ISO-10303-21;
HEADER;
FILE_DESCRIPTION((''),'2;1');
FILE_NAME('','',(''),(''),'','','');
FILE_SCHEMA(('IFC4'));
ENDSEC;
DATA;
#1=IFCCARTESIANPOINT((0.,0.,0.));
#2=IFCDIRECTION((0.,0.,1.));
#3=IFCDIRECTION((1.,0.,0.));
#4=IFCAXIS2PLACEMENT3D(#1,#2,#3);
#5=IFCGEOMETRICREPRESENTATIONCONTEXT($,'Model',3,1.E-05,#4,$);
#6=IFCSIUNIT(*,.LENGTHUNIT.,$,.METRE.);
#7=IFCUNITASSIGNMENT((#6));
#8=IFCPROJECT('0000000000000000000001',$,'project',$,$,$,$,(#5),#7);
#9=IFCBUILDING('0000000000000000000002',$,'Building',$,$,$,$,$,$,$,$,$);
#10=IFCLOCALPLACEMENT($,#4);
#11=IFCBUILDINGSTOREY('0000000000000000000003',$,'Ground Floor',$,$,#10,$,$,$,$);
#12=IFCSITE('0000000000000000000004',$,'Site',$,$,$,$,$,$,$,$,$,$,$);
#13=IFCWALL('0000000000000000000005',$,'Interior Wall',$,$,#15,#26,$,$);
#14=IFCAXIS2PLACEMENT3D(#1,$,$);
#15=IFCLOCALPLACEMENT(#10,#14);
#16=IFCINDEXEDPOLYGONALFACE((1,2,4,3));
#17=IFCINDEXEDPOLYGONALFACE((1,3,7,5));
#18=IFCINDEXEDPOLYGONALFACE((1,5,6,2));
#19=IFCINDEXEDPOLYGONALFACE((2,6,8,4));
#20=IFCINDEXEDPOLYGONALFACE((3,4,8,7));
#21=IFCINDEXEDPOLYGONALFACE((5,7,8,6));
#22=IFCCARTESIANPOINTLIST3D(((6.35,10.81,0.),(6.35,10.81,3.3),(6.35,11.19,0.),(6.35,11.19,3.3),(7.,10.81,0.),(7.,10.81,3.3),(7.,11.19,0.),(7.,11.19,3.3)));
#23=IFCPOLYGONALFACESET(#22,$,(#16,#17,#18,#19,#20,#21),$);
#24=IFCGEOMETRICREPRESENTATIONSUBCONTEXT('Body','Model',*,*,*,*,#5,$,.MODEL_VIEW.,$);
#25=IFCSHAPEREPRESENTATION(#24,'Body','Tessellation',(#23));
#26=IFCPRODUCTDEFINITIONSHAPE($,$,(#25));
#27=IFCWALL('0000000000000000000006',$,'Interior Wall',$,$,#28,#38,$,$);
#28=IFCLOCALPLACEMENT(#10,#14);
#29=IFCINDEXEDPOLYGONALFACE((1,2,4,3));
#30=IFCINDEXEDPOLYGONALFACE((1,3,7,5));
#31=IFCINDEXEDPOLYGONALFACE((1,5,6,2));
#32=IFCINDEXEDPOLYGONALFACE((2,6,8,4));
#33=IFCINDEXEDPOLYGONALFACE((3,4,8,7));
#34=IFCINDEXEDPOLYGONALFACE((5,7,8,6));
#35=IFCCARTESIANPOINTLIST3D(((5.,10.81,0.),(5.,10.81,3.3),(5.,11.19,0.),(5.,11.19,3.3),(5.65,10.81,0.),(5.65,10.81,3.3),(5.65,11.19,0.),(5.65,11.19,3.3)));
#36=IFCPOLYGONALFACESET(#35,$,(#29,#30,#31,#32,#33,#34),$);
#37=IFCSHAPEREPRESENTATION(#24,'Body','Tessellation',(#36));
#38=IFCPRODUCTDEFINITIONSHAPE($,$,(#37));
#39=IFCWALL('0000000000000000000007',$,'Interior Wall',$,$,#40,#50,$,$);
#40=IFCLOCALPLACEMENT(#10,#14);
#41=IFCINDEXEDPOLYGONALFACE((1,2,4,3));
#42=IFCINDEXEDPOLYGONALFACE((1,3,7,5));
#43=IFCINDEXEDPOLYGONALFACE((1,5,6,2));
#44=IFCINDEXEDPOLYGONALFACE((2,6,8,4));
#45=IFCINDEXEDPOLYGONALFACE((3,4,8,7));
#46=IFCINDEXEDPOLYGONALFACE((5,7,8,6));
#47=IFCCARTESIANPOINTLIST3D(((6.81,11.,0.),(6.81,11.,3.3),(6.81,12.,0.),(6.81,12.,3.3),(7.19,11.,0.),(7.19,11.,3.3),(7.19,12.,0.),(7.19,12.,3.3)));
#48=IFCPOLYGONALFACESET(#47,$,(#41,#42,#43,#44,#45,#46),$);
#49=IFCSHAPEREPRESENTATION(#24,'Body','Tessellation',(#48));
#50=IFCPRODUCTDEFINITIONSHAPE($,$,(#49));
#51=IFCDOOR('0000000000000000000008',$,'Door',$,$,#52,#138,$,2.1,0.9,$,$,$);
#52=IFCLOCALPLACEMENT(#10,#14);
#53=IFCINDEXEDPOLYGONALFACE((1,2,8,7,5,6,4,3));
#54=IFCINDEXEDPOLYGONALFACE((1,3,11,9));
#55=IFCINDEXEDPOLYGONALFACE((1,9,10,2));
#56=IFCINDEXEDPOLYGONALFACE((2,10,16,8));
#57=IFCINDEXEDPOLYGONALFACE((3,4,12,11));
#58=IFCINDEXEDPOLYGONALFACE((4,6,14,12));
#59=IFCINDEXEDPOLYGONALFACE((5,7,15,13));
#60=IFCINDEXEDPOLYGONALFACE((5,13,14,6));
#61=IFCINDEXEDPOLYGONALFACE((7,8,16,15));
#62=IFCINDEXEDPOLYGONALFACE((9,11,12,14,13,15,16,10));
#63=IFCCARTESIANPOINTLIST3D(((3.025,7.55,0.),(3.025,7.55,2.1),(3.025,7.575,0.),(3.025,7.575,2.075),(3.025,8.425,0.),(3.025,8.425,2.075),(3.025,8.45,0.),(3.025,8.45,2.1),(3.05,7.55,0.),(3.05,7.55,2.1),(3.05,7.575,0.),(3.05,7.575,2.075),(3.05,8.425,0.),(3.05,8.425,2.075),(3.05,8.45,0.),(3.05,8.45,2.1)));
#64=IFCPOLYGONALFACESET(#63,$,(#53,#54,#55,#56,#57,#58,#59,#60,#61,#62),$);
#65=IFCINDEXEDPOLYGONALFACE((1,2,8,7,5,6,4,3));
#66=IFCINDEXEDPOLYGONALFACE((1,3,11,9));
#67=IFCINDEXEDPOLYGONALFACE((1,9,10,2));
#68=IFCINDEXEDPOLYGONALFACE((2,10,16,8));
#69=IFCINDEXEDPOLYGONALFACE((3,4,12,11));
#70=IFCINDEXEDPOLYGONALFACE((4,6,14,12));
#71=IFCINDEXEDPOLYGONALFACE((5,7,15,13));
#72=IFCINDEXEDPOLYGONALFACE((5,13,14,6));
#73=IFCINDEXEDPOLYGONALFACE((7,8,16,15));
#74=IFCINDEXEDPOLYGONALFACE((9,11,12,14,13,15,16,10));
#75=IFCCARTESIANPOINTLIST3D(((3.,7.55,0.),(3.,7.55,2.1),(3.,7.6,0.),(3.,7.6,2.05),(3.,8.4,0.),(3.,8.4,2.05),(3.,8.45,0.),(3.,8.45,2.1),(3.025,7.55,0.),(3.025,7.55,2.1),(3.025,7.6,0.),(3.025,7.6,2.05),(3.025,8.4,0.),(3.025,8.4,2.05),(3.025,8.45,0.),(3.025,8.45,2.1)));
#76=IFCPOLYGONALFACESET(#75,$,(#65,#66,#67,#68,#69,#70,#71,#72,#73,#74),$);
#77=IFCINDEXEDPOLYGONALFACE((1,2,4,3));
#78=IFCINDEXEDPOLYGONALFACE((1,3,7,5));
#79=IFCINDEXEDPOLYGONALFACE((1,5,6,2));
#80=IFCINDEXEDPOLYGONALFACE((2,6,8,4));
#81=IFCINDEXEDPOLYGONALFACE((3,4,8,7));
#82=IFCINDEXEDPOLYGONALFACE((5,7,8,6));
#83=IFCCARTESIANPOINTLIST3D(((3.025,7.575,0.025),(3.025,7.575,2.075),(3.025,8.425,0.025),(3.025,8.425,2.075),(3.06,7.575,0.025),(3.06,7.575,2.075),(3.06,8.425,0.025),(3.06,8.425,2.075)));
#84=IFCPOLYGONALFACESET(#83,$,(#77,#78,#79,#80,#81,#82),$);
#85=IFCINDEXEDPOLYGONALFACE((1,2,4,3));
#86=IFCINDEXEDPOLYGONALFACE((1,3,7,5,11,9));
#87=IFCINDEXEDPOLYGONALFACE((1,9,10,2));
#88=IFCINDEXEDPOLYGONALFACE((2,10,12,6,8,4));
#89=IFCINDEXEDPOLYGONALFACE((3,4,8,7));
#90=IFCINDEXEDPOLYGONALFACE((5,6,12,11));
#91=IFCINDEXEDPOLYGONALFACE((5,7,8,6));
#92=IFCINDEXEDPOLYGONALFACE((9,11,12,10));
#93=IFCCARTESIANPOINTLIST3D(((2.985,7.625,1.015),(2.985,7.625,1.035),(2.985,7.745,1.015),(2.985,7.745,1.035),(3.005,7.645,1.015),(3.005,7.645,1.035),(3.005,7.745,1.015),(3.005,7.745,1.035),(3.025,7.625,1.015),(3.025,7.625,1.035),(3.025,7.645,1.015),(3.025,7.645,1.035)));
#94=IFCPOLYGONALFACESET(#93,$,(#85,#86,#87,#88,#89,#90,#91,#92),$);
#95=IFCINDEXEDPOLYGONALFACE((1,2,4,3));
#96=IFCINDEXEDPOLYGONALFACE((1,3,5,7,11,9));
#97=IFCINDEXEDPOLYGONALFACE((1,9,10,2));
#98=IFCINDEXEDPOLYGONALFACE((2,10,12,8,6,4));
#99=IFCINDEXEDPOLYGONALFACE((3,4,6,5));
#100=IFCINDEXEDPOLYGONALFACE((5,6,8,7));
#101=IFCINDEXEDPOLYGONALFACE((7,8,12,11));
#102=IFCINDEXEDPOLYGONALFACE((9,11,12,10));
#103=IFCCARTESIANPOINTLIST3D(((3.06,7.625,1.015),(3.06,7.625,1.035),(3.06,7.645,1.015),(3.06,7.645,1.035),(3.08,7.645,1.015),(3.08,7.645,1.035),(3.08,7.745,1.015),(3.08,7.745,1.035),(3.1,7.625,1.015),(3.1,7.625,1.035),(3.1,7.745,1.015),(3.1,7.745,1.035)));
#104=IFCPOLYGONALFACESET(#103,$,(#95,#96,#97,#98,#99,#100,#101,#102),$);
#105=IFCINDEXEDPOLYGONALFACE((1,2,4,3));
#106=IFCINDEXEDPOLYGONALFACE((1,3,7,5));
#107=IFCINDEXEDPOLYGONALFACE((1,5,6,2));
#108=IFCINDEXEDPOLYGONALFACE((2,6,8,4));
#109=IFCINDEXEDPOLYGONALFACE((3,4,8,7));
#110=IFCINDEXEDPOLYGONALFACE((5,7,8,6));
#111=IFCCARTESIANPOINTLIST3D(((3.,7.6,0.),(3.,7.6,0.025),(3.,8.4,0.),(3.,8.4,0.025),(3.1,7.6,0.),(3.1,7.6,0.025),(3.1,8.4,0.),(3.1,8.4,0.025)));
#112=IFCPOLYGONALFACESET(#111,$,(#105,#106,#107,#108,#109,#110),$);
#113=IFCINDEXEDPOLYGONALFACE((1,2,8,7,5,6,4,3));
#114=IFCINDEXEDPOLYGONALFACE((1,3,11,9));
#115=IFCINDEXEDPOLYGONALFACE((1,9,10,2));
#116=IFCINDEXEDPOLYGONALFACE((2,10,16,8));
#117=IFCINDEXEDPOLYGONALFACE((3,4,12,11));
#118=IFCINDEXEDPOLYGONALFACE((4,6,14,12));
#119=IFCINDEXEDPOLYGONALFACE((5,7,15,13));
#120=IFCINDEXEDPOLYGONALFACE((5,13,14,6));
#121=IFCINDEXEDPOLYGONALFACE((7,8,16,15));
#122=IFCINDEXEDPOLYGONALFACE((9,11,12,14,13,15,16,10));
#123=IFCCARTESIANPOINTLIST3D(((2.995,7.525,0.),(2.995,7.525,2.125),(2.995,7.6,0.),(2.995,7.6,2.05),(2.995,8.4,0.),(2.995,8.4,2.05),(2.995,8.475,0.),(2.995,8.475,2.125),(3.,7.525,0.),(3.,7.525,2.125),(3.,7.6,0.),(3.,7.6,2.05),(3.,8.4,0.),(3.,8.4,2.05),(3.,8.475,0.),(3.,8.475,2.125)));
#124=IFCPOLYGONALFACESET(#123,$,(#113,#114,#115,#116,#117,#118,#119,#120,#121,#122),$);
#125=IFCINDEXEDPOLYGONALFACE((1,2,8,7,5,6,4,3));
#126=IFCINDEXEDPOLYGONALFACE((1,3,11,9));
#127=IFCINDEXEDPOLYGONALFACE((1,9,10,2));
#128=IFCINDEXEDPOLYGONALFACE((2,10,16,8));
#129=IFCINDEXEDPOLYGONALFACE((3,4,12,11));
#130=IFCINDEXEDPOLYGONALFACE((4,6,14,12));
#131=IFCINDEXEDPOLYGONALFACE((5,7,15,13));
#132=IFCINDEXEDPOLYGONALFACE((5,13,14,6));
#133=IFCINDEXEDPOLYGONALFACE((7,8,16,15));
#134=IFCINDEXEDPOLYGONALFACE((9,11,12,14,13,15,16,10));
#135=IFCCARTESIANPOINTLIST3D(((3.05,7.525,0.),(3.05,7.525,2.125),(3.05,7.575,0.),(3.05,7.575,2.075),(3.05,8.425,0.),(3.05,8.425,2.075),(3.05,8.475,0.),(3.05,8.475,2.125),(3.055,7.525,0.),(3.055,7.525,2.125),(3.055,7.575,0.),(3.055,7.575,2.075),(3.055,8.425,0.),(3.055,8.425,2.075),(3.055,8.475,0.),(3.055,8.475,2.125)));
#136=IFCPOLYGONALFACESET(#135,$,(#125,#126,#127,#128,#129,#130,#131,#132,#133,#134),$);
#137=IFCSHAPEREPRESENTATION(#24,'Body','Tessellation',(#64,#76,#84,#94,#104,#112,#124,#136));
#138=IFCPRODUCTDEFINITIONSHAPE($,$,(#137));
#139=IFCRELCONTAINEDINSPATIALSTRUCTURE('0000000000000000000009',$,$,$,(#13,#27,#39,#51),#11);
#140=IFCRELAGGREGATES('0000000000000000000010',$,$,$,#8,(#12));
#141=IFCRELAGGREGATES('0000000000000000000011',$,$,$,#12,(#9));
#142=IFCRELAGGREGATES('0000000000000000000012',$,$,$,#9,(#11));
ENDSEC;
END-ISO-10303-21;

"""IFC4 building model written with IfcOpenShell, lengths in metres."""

from ifc_helpers import new_model, si_unit, frame, origin_with_axes, place, context, subcontext, project, spatial, line, indexed_curve, outline, extrude, element, save


model = new_model("IFC4")

# Units and contexts
model_context = context("Model", 3, precision=1e-05, world=origin_with_axes())
body_context = subcontext(model_context, "Body", "Model", "MODEL_VIEW")
ifc_project = project(units=[si_unit("LENGTHUNIT", "METRE")], contexts=[model_context])

# Site, building, storey
site = spatial("IfcSite", under=ifc_project, Name="Site")
building = spatial("IfcBuilding", under=site, Name="Building")
storey_placement = place(None, origin_with_axes())
storey = spatial("IfcBuildingStorey", under=building, at=storey_placement, Name="Ground Floor")

# Walls
for number, where, z_axis, x_axis, name in (
    (1, (7.0, 11.0, 0.0), (0.0, 0.0, 1.0), (-1.0, 0.0, 0.0), "Interior Wall"),
    (2, (5.65, 11.0, 0.0), (0.0, 0.0, 1.0), (-1.0, 0.0, 0.0), "Interior Wall"),
):
    element("IfcWall", number, at=place(storey_placement, frame(where, z_axis=z_axis, x_axis=x_axis)), inside=storey, Name=name, context=body_context, shape_type="SweptSolid", body=[
        extrude(outline(indexed_curve([(0.0, 0.0), (0.0, 0.38), (0.65, 0.38), (0.65, 0.0), (0.0, 0.0)], self_intersect=False)), frame((0.0, -0.19, 0.0), z_axis=(0.0, 0.0, 1.0), x_axis=(1.0, 0.0, 0.0)), (0.0, 0.0, 1.0), 3.3),
    ])
wall_1_placement = place(storey_placement, frame((7.0, 11.0, 0.0), z_axis=(0.0, 0.0, 1.0), x_axis=(0.0, 1.0, 0.0)))
element("IfcWall", 3, at=wall_1_placement, inside=storey, Name="Interior Wall", context=body_context, shape_type="SweptSolid", body=[
    extrude(outline(indexed_curve([(0.0, 0.0), (0.0, 0.38), (1.0, 0.38), (1.0, 0.0), (0.0, 0.0)], self_intersect=False)), frame((0.0, -0.19, 0.0), z_axis=(0.0, 0.0, 1.0), x_axis=(1.0, 0.0, 0.0)), (0.0, 0.0, 1.0), 3.3),
])

# Door
door_1_placement = place(storey_placement, frame((3.0, 8.45, 0.0), z_axis=(0.0, 0.0, 1.0), x_axis=(0.0, -1.0, 0.0)))
element("IfcDoor", 4, at=door_1_placement, inside=storey, Name="Door", OverallHeight=2.1, OverallWidth=0.9, context=body_context, shape_type="SweptSolid", body=[
    extrude(outline(indexed_curve([(0.0, 0.0), (0.0, 2.1), (0.9, 2.1), (0.9, 0.0), (0.875, 0.0), (0.875, 2.075), (0.025, 2.075), (0.025, 0.0)], segments=[line(1, 2, 3, 4, 5, 6, 7, 8, 1)])), frame((0.0, 0.025, 0.0), z_axis=(0.0, -1.0, 0.0), x_axis=(1.0, 0.0, 0.0)), (0.0, 0.0, -1.0), 0.025),
    extrude(outline(indexed_curve([(0.0, 0.0), (0.0, 2.1), (0.9, 2.1), (0.9, 0.0), (0.85, 0.0), (0.85, 2.05), (0.05, 2.05), (0.05, 0.0)], segments=[line(1, 2, 3, 4, 5, 6, 7, 8, 1)])), frame((0.0, 0.0, 0.0), z_axis=(0.0, -1.0, 0.0), x_axis=(1.0, 0.0, 0.0)), (0.0, 0.0, -1.0), 0.025),
    extrude(outline(indexed_curve([(0.0, 0.0), (0.85, 0.0), (0.85, 0.035), (0.0, 0.035)], segments=[line(1, 2, 3, 4, 1)])), frame((0.025, 0.025, 0.025), z_axis=(0.0, 0.0, 1.0), x_axis=(1.0, 0.0, 0.0)), (0.0, 0.0, 1.0), 2.05),
    extrude(outline(indexed_curve([(0.0, 0.0), (0.0, -0.04), (-0.12, -0.04), (-0.12, -0.02), (-0.02, -0.02), (-0.02, 0.0)], segments=[line(1, 2, 3, 4, 5, 6, 1)])), frame((0.825, 0.025, 1.015), z_axis=(0.0, 0.0, 1.0), x_axis=(1.0, 0.0, 0.0)), (0.0, 0.0, 1.0), 0.02),
    extrude(outline(indexed_curve([(0.0, 0.0), (0.0, 0.04), (-0.12, 0.04), (-0.12, 0.02), (-0.02, 0.02), (-0.02, 0.0)], segments=[line(1, 2, 3, 4, 5, 6, 1)])), frame((0.825, 0.06, 1.015), z_axis=(0.0, 0.0, 1.0), x_axis=(1.0, 0.0, 0.0)), (0.0, 0.0, 1.0), 0.02),
    extrude(outline(indexed_curve([(0.0, 0.0), (0.8, 0.0), (0.8, 0.1), (0.0, 0.1)], segments=[line(1, 2, 3, 4, 1)])), frame((0.05, 0.0, 0.0), z_axis=(0.0, 0.0, 1.0), x_axis=(1.0, 0.0, 0.0)), (0.0, 0.0, 1.0), 0.025),
    extrude(outline(indexed_curve([(0.0, 0.0), (0.0, 2.125), (0.95, 2.125), (0.95, 0.0), (0.875, 0.0), (0.875, 2.05), (0.075, 2.05), (0.075, 0.0)], segments=[line(1, 2, 3, 4, 5, 6, 7, 8, 1)])), frame((-0.025, -0.005, 0.0), z_axis=(0.0, -1.0, 0.0), x_axis=(1.0, 0.0, 0.0)), (0.0, 0.0, -1.0), 0.005),
    extrude(outline(indexed_curve([(0.0, 0.0), (0.0, 2.125), (0.95, 2.125), (0.95, 0.0), (0.9, 0.0), (0.9, 2.075), (0.05, 2.075), (0.05, 0.0)], segments=[line(1, 2, 3, 4, 5, 6, 7, 8, 1)])), frame((-0.025, 0.05, 0.0), z_axis=(0.0, -1.0, 0.0), x_axis=(1.0, 0.0, 0.0)), (0.0, 0.0, -1.0), 0.005),
])

save(model, "model.ifc")
